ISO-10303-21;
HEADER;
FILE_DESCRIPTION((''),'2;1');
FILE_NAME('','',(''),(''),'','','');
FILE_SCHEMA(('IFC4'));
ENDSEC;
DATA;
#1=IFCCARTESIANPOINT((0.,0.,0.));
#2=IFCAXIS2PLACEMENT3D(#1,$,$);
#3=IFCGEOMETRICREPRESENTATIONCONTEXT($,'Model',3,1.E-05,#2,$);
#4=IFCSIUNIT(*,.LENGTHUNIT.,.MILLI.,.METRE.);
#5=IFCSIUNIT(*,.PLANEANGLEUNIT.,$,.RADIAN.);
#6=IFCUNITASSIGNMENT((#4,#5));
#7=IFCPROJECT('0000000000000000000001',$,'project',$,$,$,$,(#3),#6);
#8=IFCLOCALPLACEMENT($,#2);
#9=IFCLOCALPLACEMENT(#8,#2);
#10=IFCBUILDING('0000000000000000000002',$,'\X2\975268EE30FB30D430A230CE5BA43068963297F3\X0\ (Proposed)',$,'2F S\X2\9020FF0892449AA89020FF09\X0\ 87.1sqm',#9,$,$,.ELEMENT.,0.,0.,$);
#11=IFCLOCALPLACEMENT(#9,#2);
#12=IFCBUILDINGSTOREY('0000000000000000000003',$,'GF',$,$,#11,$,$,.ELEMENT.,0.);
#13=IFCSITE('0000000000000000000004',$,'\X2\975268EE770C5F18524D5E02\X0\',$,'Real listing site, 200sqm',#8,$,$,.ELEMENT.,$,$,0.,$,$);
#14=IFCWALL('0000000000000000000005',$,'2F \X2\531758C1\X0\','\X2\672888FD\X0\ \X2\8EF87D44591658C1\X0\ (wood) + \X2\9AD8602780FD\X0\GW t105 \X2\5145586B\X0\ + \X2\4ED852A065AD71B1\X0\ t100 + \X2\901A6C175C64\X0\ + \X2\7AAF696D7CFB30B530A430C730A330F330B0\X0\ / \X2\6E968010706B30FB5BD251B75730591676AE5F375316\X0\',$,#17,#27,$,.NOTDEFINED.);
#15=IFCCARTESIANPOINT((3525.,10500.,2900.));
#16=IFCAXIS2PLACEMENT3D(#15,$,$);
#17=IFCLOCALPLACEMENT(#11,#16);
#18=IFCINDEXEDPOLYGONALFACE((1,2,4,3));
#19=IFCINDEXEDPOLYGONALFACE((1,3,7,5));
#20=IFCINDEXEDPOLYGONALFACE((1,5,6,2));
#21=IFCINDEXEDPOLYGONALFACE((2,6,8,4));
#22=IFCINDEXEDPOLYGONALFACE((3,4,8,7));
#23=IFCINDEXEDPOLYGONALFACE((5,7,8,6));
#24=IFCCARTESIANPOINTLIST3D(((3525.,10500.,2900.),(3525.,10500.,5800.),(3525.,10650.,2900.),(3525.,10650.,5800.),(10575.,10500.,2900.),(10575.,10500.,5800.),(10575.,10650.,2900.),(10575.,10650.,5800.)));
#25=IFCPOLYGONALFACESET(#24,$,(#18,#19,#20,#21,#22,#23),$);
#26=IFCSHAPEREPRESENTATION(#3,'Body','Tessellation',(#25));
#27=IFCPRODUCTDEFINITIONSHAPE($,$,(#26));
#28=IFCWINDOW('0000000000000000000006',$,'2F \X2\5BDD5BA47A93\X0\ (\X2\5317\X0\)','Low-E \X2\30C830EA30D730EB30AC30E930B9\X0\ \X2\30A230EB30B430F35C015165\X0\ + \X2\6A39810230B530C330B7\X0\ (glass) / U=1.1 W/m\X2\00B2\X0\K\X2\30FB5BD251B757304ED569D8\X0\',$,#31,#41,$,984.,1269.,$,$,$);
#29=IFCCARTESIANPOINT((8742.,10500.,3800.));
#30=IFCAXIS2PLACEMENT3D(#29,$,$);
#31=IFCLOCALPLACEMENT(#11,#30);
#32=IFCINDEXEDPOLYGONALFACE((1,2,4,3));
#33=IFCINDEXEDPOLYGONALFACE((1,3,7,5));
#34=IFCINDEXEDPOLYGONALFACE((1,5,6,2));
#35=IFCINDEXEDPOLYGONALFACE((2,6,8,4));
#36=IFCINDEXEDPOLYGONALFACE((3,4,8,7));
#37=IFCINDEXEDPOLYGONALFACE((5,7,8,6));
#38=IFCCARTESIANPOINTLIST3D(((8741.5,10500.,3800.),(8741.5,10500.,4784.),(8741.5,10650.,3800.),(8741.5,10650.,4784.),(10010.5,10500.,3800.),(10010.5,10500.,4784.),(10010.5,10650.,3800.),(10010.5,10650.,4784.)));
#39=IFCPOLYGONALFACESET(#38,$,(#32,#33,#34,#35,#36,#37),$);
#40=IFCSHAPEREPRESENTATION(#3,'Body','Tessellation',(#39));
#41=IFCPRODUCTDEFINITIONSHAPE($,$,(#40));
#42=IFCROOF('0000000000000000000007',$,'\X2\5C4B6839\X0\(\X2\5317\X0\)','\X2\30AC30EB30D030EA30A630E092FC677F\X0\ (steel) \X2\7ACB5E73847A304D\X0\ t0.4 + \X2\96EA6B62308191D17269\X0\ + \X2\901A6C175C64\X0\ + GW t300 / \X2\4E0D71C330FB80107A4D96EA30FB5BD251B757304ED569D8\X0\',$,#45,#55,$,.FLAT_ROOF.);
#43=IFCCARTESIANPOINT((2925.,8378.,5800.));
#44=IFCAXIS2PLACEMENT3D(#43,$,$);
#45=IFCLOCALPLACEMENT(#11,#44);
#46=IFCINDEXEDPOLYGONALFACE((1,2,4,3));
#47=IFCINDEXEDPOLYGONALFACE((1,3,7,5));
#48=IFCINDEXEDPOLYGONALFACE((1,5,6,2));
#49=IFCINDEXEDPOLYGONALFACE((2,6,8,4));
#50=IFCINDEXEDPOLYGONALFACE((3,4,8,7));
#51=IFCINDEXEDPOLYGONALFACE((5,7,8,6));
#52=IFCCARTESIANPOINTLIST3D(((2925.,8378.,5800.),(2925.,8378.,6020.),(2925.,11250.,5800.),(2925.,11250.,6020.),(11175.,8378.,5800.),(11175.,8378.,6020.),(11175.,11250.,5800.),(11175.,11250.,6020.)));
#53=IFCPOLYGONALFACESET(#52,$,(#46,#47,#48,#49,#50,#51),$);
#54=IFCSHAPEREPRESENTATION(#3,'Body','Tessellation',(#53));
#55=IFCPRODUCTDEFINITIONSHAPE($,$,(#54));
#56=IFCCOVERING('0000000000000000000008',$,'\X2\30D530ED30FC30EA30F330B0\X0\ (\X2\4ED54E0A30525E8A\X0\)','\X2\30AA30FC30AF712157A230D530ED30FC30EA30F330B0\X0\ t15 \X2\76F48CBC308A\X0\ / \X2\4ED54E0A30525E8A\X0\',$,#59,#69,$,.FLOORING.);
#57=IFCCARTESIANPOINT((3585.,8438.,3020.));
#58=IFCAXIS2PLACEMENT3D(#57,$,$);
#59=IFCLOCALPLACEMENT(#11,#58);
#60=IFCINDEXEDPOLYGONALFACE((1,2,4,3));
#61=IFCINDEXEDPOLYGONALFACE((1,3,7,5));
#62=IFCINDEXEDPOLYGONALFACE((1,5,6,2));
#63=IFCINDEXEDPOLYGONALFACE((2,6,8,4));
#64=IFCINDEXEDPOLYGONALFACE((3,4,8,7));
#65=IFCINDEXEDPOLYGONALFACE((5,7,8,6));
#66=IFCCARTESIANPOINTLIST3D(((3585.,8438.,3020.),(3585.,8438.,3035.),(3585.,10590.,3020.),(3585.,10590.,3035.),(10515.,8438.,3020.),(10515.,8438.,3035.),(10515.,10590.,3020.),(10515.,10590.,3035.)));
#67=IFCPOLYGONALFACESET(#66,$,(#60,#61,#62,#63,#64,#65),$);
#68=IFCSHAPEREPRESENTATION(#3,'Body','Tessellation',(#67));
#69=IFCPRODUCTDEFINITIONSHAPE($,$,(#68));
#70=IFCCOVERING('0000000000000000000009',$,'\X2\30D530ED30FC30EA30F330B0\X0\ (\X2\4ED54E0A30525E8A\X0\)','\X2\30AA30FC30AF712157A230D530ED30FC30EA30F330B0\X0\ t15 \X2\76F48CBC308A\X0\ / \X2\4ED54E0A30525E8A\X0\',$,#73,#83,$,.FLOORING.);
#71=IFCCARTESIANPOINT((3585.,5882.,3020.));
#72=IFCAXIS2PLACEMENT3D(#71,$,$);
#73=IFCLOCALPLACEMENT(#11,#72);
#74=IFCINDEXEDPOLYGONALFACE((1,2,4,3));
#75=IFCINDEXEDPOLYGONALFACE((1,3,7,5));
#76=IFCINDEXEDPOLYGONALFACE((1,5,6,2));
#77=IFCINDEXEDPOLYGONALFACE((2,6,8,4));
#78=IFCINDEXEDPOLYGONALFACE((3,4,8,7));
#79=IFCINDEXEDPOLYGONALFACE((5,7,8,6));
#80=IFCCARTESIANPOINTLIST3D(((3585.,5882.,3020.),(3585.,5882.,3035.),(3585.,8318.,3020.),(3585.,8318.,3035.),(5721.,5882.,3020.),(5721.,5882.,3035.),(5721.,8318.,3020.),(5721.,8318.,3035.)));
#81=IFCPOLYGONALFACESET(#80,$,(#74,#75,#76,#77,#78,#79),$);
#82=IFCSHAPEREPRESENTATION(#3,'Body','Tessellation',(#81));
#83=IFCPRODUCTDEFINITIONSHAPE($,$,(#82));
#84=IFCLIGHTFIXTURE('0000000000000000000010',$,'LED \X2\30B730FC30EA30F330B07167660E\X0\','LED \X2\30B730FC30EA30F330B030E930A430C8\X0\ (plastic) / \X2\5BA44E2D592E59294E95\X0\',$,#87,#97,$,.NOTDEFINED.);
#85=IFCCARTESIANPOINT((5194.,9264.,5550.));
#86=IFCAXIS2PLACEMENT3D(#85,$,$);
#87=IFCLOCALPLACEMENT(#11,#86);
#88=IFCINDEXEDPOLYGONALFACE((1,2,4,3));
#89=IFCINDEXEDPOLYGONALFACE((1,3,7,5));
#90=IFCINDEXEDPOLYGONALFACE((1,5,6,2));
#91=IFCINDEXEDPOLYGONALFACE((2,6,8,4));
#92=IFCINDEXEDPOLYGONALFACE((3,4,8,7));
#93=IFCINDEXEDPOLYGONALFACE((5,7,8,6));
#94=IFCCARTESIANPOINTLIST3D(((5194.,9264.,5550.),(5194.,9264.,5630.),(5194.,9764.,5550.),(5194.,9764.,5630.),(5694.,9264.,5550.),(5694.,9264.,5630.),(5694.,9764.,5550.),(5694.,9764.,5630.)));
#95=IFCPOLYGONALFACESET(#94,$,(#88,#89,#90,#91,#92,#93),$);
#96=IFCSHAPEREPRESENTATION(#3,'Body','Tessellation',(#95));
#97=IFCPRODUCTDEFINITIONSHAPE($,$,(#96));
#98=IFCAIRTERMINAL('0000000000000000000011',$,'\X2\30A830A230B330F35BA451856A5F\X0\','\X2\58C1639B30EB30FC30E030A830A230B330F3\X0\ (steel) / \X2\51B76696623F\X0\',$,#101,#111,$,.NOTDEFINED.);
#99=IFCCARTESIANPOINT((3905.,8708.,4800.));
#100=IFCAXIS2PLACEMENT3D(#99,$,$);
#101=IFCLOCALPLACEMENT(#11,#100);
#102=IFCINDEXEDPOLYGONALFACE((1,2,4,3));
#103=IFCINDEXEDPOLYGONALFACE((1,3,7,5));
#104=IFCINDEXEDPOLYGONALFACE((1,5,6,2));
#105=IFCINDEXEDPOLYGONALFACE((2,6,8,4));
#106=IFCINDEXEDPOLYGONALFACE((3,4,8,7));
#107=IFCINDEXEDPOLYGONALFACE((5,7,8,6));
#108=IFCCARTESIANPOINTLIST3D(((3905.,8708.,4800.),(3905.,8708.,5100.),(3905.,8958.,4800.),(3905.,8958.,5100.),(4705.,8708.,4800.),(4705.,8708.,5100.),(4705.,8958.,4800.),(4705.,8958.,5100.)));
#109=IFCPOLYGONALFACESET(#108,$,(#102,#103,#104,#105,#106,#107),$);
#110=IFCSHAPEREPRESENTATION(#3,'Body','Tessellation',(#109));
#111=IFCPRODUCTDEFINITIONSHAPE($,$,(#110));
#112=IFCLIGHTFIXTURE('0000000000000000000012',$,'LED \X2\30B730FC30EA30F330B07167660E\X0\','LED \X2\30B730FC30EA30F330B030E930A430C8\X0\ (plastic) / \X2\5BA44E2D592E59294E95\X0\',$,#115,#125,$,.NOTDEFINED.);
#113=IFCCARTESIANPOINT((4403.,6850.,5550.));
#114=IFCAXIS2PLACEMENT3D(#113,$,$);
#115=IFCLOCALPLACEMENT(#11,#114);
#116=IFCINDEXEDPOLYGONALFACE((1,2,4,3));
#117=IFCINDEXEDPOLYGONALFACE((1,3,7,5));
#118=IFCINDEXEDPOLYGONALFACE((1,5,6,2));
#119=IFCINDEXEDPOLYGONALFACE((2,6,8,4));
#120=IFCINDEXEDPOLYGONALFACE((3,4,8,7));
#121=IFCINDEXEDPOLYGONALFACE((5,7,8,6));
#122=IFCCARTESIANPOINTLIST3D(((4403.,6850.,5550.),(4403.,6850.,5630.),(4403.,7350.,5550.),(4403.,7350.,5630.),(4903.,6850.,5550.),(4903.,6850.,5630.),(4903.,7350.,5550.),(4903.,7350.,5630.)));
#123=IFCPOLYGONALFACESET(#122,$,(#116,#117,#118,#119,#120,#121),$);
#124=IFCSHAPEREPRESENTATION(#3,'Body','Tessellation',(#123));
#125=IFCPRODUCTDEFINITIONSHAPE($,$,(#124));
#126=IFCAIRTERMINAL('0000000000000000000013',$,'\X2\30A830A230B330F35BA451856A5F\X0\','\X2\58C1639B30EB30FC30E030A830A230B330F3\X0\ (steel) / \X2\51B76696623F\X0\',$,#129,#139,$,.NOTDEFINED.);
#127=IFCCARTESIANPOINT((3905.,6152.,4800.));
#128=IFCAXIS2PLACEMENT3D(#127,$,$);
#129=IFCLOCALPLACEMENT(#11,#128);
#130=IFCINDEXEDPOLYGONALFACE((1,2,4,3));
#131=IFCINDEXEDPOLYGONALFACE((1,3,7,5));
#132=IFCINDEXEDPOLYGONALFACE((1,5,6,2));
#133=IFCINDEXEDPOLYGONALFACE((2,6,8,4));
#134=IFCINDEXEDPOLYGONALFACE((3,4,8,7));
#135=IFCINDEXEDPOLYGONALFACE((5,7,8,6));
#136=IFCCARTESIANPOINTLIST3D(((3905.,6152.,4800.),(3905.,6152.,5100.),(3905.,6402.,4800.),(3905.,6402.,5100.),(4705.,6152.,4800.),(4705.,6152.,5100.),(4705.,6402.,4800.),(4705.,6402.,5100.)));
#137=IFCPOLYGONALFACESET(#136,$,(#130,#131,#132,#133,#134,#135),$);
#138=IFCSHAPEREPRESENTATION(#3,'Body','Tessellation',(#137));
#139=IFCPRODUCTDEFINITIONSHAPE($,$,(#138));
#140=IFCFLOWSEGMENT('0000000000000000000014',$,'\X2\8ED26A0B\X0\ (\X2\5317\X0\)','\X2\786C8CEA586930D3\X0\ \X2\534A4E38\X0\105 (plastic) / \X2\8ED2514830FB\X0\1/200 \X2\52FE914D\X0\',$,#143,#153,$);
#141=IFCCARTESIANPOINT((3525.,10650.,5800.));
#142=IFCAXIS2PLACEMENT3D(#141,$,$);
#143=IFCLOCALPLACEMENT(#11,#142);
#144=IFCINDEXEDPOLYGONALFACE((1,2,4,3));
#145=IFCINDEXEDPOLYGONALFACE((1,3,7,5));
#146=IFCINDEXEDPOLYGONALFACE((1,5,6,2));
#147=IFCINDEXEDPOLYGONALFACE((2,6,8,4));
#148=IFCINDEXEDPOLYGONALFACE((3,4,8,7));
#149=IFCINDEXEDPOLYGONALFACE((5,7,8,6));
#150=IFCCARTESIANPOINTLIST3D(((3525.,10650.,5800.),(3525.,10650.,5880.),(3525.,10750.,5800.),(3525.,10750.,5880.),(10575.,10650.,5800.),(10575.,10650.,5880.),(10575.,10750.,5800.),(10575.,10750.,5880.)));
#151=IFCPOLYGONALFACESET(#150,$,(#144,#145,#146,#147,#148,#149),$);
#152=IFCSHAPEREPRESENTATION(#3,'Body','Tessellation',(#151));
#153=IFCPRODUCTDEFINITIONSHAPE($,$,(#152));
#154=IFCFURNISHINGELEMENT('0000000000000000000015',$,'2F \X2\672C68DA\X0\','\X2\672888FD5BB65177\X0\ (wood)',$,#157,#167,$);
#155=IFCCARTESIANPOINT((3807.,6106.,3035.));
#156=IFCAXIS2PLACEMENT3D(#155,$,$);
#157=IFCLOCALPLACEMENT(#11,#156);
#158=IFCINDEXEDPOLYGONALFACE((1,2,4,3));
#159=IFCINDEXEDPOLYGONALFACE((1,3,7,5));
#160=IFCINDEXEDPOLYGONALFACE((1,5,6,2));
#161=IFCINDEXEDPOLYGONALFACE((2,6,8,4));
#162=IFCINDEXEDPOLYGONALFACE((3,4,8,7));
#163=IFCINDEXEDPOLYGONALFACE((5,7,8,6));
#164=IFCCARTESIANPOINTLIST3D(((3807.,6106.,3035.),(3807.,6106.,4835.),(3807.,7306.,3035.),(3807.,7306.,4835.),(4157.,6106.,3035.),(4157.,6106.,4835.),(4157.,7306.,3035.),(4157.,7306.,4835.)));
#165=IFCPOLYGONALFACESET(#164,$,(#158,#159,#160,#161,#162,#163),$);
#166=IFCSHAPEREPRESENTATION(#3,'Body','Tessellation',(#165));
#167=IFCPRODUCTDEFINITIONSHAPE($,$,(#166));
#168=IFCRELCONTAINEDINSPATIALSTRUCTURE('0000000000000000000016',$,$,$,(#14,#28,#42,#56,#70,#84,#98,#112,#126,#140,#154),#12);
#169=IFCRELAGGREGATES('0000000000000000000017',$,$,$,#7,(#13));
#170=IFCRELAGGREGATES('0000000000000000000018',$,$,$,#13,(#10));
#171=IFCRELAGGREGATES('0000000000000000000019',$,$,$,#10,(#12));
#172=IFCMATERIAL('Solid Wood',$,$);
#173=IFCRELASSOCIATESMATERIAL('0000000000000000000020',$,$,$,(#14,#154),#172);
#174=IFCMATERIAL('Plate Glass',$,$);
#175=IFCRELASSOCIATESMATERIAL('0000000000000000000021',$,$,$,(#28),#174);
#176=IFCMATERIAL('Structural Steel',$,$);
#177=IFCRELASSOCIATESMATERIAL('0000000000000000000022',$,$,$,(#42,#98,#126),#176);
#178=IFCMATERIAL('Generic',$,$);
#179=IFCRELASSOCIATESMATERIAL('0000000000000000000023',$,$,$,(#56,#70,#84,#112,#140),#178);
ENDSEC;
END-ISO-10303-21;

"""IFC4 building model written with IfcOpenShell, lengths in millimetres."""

from ifc_helpers import new_model, si_unit, frame, frame_2d, origin, place, context, project, spatial, rectangle, extrude, material, element, fill, save


model = new_model("IFC4")

# Units and contexts
model_context = context("Model", 3, precision=1e-05, world=origin())
ifc_project = project(units=[si_unit("LENGTHUNIT", "METRE", prefix="MILLI"), si_unit("PLANEANGLEUNIT", "RADIAN")], contexts=[model_context])

# Site, building, storey
site_placement = place(None, origin())
site = spatial("IfcSite", under=ifc_project, at=site_placement, Name="青森県弘前市", ObjectType="Real listing site, 200sqm", CompositionType="ELEMENT", RefElevation=0.0)
building_placement = place(site_placement, origin())
building = spatial("IfcBuilding", under=site, at=building_placement, Name="青森・ピアノ室と防音 (Proposed)", ObjectType="2F S造（鉄骨造） 87.1sqm", CompositionType="ELEMENT", ElevationOfRefHeight=0.0, ElevationOfTerrain=0.0)
storey_placement = place(building_placement, origin())
storey = spatial("IfcBuildingStorey", under=building, at=storey_placement, Name="GF", CompositionType="ELEMENT", Elevation=0.0)

# Shared definitions
ifc_material_1 = material(Name="Solid Wood")

# Wall, opening, window
wall_placement = place(storey_placement, frame((3525.0, 10500.0, 2900.0)))
wall = element("IfcWall", 1, at=wall_placement, inside=storey, material=ifc_material_1, Name="2F 北壁", Description="木製 軸組外壁 (wood) + 高性能GW t105 充填 + 付加断熱 t100 + 通気層 + 窯業系サイディング / 準耐火・寒冷地外皮強化", PredefinedType="NOTDEFINED", context=model_context, shape_type="SweptSolid", body=[
    extrude(rectangle(XDim=7050.0, YDim=150.0, at=frame_2d((3525.0, 75.0))), frame((3525.0, 10500.0, 2900.0)), (0.0, 0.0, 1.0), 2900.0),
])
opening_placement = place(storey_placement, frame((8742.0, 10500.0, 3800.0)))
opening = element("IfcOpeningElement", 2, at=opening_placement, cuts=wall, PredefinedType="NOTDEFINED", context=model_context, shape_type="SweptSolid", body=[
    extrude(rectangle(XDim=1269.0, YDim=150.0, at=frame_2d((634.0, 75.0))), frame((8742.0, 10500.0, 3800.0)), (0.0, 0.0, 1.0), 984.0),
])
ifc_material_2 = material(Name="Plate Glass")
window_placement = place(storey_placement, frame((8742.0, 10500.0, 3800.0)))
window = element("IfcWindow", 3, at=window_placement, inside=storey, material=ifc_material_2, Name="2F 寝室窓 (北)", Description="Low-E トリプルガラス アルゴン封入 + 樹脂サッシ (glass) / U=1.1 W/m²K・寒冷地仕様", OverallHeight=984.0, OverallWidth=1269.0, context=model_context, shape_type="SweptSolid", body=[
    extrude(rectangle(XDim=1269.0, YDim=150.0, at=frame_2d((634.0, 75.0))), frame((8742.0, 10500.0, 3800.0)), (0.0, 0.0, 1.0), 984.0),
])
fill(opening, window)

# Roof
ifc_material_3 = material(Name="Structural Steel")
for number, where, name in (
    (4, (2925.0, 8378.0, 5800.0), "屋根(北)"),
):
    element("IfcRoof", number, at=place(storey_placement, frame(where)), inside=storey, material=ifc_material_3, Name=name, Description="ガルバリウム鋼板 (steel) 立平葺き t0.4 + 雪止め金物 + 通気層 + GW t300 / 不燃・耐積雪・寒冷地仕様", PredefinedType="FLAT_ROOF", context=model_context, shape_type="SweptSolid", body=[
        extrude(rectangle(XDim=8250.0, YDim=2872.0, at=frame_2d((4125.0, 1436.0))), frame((2925.0, 8378.0, 5800.0)), (0.0, 0.0, 1.0), 220.0),
    ])

# Coverings
ifc_material_4 = material(Name="Generic")
covering_1_placement = place(storey_placement, frame((3585.0, 8438.0, 3020.0)))
element("IfcCovering", 5, at=covering_1_placement, inside=storey, material=ifc_material_4, Name="フローリング (仕上げ床)", Description="オーク無垢フローリング t15 直貼り / 仕上げ床", PredefinedType="FLOORING", context=model_context, shape_type="SweptSolid", body=[
    extrude(rectangle(XDim=6930.0, YDim=2152.0, at=frame_2d((3465.0, 1076.0))), frame((3585.0, 8438.0, 3020.0)), (0.0, 0.0, 1.0), 15.0),
])
covering_2_placement = place(storey_placement, frame((3585.0, 5882.0, 3020.0)))
element("IfcCovering", 6, at=covering_2_placement, inside=storey, material=ifc_material_4, Name="フローリング (仕上げ床)", Description="オーク無垢フローリング t15 直貼り / 仕上げ床", PredefinedType="FLOORING", context=model_context, shape_type="SweptSolid", body=[
    extrude(rectangle(XDim=2136.0, YDim=2436.0, at=frame_2d((1068.0, 1218.0))), frame((3585.0, 5882.0, 3020.0)), (0.0, 0.0, 1.0), 15.0),
])

# Light fixture
light_fixture_1_placement = place(storey_placement, frame((5194.0, 9264.0, 5550.0)))
element("IfcLightFixture", 7, at=light_fixture_1_placement, inside=storey, material=ifc_material_4, Name="LED シーリング照明", Description="LED シーリングライト (plastic) / 室中央天井", PredefinedType="NOTDEFINED", context=model_context, shape_type="SweptSolid", body=[
    extrude(rectangle(XDim=500.0, YDim=500.0, at=frame_2d((250.0, 250.0))), frame((5194.0, 9264.0, 5550.0)), (0.0, 0.0, 1.0), 80.0),
])

# Air terminal
air_terminal_1_placement = place(storey_placement, frame((3905.0, 8708.0, 4800.0)))
element("IfcAirTerminal", 8, at=air_terminal_1_placement, inside=storey, material=ifc_material_3, Name="エアコン室内機", Description="壁掛ルームエアコン (steel) / 冷暖房", PredefinedType="NOTDEFINED", context=model_context, shape_type="SweptSolid", body=[
    extrude(rectangle(XDim=800.0, YDim=250.0, at=frame_2d((400.0, 125.0))), frame((3905.0, 8708.0, 4800.0)), (0.0, 0.0, 1.0), 300.0),
])

# Light fixture
light_fixture_2_placement = place(storey_placement, frame((4403.0, 6850.0, 5550.0)))
element("IfcLightFixture", 9, at=light_fixture_2_placement, inside=storey, material=ifc_material_4, Name="LED シーリング照明", Description="LED シーリングライト (plastic) / 室中央天井", PredefinedType="NOTDEFINED", context=model_context, shape_type="SweptSolid", body=[
    extrude(rectangle(XDim=500.0, YDim=500.0, at=frame_2d((250.0, 250.0))), frame((4403.0, 6850.0, 5550.0)), (0.0, 0.0, 1.0), 80.0),
])

# Air terminal
air_terminal_2_placement = place(storey_placement, frame((3905.0, 6152.0, 4800.0)))
element("IfcAirTerminal", 10, at=air_terminal_2_placement, inside=storey, material=ifc_material_3, Name="エアコン室内機", Description="壁掛ルームエアコン (steel) / 冷暖房", PredefinedType="NOTDEFINED", context=model_context, shape_type="SweptSolid", body=[
    extrude(rectangle(XDim=800.0, YDim=250.0, at=frame_2d((400.0, 125.0))), frame((3905.0, 6152.0, 4800.0)), (0.0, 0.0, 1.0), 300.0),
])

# Flow segment
flow_segment_placement = place(storey_placement, frame((3525.0, 10650.0, 5800.0)))
element("IfcFlowSegment", 11, at=flow_segment_placement, inside=storey, material=ifc_material_4, Name="軒樋 (北)", Description="硬質塩ビ 半丸105 (plastic) / 軒先・1/200 勾配", context=model_context, shape_type="SweptSolid", body=[
    extrude(rectangle(XDim=7050.0, YDim=100.0, at=frame_2d((3525.0, 50.0))), frame((3525.0, 10650.0, 5800.0)), (0.0, 0.0, 1.0), 80.0),
])

# Furnishing element
furnishing_placement = place(storey_placement, frame((3807.0, 6106.0, 3035.0)))
element("IfcFurnishingElement", 12, at=furnishing_placement, inside=storey, material=ifc_material_1, Name="2F 本棚", Description="木製家具 (wood)", context=model_context, shape_type="SweptSolid", body=[
    extrude(rectangle(XDim=350.0, YDim=1200.0, at=frame_2d((175.0, 600.0))), frame((3807.0, 6106.0, 3035.0)), (0.0, 0.0, 1.0), 1800.0),
])

save(model, "model.ifc")
